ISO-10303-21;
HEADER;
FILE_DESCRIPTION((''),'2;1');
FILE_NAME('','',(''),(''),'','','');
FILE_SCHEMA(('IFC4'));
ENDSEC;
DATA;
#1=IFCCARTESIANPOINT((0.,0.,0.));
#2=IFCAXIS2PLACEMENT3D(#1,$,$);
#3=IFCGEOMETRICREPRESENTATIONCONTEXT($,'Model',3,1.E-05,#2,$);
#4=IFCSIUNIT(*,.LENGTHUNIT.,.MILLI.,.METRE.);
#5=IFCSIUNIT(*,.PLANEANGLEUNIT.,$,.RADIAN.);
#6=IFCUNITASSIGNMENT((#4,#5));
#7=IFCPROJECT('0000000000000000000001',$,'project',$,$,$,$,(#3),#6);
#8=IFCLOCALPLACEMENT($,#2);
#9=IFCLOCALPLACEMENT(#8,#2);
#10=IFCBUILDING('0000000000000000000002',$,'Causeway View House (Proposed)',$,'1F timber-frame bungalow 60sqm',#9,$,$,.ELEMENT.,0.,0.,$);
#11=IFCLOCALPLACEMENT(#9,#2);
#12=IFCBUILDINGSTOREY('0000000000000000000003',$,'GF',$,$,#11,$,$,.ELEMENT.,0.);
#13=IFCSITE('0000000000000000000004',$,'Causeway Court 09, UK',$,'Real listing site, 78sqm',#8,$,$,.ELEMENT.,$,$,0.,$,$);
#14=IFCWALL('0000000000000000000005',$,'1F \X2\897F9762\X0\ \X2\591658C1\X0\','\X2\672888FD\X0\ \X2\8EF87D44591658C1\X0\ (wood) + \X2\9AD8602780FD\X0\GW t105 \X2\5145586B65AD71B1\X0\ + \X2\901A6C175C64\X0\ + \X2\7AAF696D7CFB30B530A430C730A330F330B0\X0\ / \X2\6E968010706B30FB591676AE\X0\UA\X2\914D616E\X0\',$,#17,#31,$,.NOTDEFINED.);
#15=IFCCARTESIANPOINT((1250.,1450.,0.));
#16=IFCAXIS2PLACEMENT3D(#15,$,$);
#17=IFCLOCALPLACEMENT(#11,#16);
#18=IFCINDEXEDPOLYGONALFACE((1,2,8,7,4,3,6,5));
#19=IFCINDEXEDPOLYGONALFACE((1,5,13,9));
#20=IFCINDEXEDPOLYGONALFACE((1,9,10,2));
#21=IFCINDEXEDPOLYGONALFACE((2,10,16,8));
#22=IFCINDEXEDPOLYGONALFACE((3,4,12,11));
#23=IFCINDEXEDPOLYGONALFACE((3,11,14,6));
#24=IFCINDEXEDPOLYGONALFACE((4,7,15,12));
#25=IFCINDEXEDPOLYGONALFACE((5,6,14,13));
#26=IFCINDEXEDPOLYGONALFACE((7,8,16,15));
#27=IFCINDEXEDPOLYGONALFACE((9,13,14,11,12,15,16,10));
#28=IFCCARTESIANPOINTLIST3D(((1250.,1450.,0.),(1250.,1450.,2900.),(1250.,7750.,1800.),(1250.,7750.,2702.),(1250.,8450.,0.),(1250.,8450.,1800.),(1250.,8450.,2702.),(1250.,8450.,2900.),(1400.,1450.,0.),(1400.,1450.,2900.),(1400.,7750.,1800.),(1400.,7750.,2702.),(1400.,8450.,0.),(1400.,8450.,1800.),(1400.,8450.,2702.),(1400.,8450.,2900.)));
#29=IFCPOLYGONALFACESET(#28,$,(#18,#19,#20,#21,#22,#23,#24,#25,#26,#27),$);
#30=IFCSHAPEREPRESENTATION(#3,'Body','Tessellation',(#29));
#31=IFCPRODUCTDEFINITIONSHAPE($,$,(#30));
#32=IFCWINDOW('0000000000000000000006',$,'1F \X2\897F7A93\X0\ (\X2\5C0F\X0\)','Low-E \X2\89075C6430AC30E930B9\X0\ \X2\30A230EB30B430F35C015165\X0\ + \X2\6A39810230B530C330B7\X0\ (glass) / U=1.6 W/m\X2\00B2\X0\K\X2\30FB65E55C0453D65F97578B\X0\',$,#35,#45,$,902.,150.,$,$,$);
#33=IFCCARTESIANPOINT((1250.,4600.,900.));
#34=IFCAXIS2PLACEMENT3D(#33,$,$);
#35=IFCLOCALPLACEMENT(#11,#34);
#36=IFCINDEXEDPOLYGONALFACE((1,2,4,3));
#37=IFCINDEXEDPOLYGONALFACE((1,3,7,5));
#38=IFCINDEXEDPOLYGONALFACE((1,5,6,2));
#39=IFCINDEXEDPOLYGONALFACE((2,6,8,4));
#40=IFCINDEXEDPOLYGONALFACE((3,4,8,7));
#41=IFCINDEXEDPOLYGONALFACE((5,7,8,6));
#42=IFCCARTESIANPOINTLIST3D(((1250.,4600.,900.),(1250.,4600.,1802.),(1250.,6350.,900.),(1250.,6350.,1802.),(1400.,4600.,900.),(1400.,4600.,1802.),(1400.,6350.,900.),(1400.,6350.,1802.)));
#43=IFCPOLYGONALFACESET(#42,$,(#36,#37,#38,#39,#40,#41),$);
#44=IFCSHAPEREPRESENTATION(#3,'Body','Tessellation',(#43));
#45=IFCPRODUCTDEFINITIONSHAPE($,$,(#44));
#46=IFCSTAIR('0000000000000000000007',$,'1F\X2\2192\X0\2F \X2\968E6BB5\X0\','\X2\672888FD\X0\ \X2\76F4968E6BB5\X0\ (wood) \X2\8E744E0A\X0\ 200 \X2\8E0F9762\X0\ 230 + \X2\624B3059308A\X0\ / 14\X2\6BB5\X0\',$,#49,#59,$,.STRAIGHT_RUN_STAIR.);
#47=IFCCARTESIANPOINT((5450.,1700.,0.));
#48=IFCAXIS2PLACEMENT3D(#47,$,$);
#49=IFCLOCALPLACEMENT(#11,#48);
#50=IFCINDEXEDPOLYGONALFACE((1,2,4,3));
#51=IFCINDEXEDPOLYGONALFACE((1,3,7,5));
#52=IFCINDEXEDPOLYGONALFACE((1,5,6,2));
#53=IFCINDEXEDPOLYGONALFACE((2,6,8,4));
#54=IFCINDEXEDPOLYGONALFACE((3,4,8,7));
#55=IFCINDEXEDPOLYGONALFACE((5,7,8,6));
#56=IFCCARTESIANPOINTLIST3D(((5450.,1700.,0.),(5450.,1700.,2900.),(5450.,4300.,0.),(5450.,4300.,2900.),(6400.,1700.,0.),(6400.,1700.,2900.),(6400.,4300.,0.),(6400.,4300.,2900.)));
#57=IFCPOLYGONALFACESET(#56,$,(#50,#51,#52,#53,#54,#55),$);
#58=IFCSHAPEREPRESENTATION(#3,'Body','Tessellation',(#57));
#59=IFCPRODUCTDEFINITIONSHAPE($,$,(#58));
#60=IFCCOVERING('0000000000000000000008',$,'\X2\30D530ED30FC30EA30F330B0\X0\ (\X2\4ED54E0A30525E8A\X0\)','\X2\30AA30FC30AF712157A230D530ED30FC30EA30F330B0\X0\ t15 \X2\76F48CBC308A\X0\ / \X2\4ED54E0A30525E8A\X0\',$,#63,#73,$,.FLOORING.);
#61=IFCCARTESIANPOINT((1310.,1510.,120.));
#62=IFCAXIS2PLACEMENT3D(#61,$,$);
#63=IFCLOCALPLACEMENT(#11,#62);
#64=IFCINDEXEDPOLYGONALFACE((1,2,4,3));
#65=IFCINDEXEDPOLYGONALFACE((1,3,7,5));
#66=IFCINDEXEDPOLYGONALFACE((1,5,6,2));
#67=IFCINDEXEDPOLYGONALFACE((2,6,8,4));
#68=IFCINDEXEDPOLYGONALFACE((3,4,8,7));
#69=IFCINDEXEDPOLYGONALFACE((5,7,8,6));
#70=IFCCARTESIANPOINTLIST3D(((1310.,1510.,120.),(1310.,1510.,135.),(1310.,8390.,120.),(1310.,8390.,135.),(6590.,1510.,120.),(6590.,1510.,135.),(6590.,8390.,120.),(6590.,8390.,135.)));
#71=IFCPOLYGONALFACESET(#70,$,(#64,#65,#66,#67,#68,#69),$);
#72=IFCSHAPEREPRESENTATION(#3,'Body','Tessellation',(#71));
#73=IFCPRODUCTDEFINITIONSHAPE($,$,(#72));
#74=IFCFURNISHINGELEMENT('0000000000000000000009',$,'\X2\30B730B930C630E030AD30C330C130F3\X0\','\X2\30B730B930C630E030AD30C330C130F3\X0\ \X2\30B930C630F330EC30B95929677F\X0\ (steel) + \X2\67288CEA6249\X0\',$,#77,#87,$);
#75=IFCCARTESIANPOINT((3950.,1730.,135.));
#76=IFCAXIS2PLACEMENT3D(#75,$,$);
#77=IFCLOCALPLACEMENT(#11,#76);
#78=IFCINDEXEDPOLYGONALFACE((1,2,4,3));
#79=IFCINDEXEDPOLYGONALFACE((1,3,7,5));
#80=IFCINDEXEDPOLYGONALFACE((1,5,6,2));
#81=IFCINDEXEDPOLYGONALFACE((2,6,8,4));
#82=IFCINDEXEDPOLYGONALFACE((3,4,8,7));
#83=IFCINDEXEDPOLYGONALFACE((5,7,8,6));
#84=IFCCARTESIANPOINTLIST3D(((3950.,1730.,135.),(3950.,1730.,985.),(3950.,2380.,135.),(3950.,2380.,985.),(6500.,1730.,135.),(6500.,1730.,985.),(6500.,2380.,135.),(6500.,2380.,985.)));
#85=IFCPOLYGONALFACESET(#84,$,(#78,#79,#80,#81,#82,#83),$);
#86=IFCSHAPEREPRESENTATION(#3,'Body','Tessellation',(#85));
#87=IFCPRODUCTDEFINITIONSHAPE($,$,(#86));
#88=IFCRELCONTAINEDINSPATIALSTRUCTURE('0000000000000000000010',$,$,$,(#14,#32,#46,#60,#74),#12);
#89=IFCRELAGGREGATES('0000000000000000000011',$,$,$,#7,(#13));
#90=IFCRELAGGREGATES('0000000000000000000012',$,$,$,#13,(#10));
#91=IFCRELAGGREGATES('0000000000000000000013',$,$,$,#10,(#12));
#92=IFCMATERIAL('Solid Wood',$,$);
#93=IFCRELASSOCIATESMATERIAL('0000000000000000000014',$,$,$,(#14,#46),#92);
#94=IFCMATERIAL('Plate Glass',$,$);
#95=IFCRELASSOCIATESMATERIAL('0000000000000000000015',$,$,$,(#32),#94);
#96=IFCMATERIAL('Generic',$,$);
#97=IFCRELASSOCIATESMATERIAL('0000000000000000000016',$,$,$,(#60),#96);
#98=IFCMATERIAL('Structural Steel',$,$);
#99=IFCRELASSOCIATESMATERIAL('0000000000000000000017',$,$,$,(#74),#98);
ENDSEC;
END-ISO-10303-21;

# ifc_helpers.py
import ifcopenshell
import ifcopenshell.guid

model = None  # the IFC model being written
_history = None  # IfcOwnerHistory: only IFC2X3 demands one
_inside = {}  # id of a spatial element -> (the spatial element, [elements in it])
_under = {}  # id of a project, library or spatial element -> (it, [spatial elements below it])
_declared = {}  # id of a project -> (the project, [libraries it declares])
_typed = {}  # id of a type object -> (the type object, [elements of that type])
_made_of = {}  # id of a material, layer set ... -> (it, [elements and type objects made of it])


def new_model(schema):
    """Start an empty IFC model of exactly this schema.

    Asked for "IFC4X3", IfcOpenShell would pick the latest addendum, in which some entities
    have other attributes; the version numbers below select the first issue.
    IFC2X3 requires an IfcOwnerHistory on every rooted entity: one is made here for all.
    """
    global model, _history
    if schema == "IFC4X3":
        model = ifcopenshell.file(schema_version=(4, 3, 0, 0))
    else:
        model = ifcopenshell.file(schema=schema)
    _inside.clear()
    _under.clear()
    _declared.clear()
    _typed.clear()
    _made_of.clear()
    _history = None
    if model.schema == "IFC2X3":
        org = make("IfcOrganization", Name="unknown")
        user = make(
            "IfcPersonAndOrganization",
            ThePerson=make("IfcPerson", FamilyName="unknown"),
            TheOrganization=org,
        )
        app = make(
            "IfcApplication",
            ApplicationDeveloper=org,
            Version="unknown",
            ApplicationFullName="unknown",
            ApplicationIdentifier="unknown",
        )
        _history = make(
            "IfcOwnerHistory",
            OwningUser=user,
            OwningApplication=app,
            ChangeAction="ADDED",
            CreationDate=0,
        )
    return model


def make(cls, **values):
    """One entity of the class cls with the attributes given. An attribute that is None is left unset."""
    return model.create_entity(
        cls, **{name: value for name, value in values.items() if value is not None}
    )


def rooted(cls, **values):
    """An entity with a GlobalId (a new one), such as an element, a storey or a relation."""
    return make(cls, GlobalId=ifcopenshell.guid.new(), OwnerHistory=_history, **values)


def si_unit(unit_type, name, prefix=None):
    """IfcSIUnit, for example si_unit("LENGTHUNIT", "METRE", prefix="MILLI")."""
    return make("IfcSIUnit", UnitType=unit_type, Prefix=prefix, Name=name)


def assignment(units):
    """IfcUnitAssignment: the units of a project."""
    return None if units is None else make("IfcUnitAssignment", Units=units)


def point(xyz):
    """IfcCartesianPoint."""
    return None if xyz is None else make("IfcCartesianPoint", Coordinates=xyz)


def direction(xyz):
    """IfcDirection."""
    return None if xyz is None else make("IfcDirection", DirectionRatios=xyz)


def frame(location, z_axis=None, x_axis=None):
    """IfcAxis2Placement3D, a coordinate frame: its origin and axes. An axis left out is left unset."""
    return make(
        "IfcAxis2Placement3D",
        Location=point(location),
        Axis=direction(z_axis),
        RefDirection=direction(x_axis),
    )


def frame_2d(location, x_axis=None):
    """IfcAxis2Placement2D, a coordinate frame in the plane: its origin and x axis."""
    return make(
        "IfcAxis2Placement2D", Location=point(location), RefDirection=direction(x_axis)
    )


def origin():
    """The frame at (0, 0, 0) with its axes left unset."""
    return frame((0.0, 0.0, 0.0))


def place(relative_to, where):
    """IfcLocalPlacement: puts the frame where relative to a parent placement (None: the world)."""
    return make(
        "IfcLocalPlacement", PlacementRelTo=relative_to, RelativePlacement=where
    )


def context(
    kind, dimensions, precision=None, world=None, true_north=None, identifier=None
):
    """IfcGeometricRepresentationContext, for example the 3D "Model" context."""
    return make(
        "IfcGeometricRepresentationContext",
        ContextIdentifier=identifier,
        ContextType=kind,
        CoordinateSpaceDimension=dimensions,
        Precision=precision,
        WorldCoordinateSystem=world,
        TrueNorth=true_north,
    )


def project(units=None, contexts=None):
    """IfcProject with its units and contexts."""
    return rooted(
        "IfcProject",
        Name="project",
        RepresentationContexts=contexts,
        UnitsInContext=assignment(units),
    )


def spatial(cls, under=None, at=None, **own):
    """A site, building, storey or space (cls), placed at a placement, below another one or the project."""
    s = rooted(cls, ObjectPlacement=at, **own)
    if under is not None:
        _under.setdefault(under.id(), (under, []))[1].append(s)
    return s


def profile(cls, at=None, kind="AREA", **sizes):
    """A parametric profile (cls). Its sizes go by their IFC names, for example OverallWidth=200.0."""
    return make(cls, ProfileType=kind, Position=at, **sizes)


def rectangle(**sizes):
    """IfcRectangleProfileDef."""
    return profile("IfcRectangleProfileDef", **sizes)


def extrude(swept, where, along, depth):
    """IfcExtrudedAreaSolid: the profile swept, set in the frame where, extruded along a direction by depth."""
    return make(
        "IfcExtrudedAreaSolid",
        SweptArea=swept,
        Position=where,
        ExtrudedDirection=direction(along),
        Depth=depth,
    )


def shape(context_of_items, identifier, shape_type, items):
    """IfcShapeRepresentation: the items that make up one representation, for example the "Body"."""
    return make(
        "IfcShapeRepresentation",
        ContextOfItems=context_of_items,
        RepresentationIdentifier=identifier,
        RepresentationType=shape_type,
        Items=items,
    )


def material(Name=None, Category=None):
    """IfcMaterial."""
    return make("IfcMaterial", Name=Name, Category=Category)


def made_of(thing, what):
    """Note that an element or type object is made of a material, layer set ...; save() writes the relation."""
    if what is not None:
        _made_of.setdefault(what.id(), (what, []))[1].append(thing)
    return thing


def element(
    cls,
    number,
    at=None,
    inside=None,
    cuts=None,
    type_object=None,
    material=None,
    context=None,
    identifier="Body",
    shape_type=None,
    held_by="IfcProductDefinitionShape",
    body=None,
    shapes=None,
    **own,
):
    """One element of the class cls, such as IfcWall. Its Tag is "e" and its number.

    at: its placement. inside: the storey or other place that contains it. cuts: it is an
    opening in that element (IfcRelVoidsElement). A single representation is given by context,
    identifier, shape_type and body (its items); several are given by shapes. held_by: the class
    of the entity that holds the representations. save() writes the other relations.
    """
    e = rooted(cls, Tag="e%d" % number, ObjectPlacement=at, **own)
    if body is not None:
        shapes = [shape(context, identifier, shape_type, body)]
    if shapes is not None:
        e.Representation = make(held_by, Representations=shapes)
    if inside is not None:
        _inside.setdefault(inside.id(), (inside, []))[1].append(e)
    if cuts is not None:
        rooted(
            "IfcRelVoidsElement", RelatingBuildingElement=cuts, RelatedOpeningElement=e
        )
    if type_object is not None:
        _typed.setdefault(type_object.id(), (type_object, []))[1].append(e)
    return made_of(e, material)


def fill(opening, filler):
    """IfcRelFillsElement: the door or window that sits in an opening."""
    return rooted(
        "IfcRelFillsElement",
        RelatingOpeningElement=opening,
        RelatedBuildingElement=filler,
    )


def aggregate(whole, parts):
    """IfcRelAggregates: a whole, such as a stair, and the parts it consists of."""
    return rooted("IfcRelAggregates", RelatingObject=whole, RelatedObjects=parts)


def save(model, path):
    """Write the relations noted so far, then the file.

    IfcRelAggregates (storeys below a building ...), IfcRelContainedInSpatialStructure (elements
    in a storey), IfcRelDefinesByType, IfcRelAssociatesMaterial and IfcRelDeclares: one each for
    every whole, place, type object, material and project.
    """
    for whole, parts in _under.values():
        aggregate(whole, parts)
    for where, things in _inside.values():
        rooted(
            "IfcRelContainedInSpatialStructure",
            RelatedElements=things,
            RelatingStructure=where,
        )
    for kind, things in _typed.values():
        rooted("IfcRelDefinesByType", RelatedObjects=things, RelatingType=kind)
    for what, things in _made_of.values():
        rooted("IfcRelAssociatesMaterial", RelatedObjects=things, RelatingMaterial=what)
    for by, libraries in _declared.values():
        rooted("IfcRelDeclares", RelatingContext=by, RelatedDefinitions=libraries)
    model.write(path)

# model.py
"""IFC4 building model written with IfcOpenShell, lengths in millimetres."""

from ifc_helpers import new_model, si_unit, frame, frame_2d, origin, place, context, project, spatial, rectangle, extrude, material, element, fill, save


model = new_model("IFC4")

# Units and contexts
model_context = context("Model", 3, precision=1e-05, world=origin())
ifc_project = project(units=[si_unit("LENGTHUNIT", "METRE", prefix="MILLI"), si_unit("PLANEANGLEUNIT", "RADIAN")], contexts=[model_context])

# Site, building, storey
site_placement = place(None, origin())
site = spatial("IfcSite", under=ifc_project, at=site_placement, Name="Causeway Court 09, UK", ObjectType="Real listing site, 78sqm", CompositionType="ELEMENT", RefElevation=0.0)
building_placement = place(site_placement, origin())
building = spatial("IfcBuilding", under=site, at=building_placement, Name="Causeway View House (Proposed)", ObjectType="1F timber-frame bungalow 60sqm", CompositionType="ELEMENT", ElevationOfRefHeight=0.0, ElevationOfTerrain=0.0)
storey_placement = place(building_placement, origin())
storey = spatial("IfcBuildingStorey", under=building, at=storey_placement, Name="GF", CompositionType="ELEMENT", Elevation=0.0)

# Shared definitions
ifc_material_1 = material(Name="Solid Wood")
ifc_material_2 = material(Name="Generic")

# Shared definitions
ifc_material_3 = material(Name="Plate Glass")

# Wall, opening, window
wall_1_placement = place(storey_placement, frame((1250.0, 1450.0, 0.0)))
wall_1 = element("IfcWall", 1, at=wall_1_placement, inside=storey, material=ifc_material_1, Name="1F 西面 外壁", Description="木製 軸組外壁 (wood) + 高性能GW t105 充填断熱 + 通気層 + 窯業系サイディング / 準耐火・外皮UA配慮", PredefinedType="NOTDEFINED", context=model_context, shape_type="SweptSolid", body=[
    extrude(rectangle(XDim=150.0, YDim=7000.0, at=frame_2d((75.0, 3500.0))), frame((1250.0, 1450.0, 0.0)), (0.0, 0.0, 1.0), 2900.0),
])
opening_1_placement = place(storey_placement, frame((1250.0, 4600.0, 900.0)))
opening_1 = element("IfcOpeningElement", 2, at=opening_1_placement, cuts=wall_1, PredefinedType="NOTDEFINED", context=model_context, shape_type="SweptSolid", body=[
    extrude(rectangle(XDim=150.0, YDim=1750.0, at=frame_2d((75.0, 875.0))), frame((1250.0, 4600.0, 900.0)), (0.0, 0.0, 1.0), 902.0),
])
window_1_placement = place(storey_placement, frame((1250.0, 4600.0, 900.0)))
window_1 = element("IfcWindow", 3, at=window_1_placement, inside=storey, material=ifc_material_3, Name="1F 西窓 (小)", Description="Low-E 複層ガラス アルゴン封入 + 樹脂サッシ (glass) / U=1.6 W/m²K・日射取得型", OverallHeight=902.0, OverallWidth=150.0, context=model_context, shape_type="SweptSolid", body=[
    extrude(rectangle(XDim=150.0, YDim=1750.0, at=frame_2d((75.0, 875.0))), frame((1250.0, 4600.0, 900.0)), (0.0, 0.0, 1.0), 902.0),
])
fill(opening_1, window_1)

# Stair
stair_placement = place(storey_placement, frame((5450.0, 1700.0, 0.0)))
element("IfcStair", 4, at=stair_placement, inside=storey, material=ifc_material_1, Name="1F→2F 階段", Description="木製 直階段 (wood) 蹴上 200 踏面 230 + 手すり / 14段", PredefinedType="STRAIGHT_RUN_STAIR", context=model_context, shape_type="SweptSolid", body=[
    extrude(rectangle(XDim=950.0, YDim=2600.0, at=frame_2d((475.0, 1300.0))), frame((5450.0, 1700.0, 0.0)), (0.0, 0.0, 1.0), 2900.0),
])

# Covering
covering_placement = place(storey_placement, frame((1310.0, 1510.0, 120.0)))
element("IfcCovering", 5, at=covering_placement, inside=storey, material=ifc_material_2, Name="フローリング (仕上げ床)", Description="オーク無垢フローリング t15 直貼り / 仕上げ床", PredefinedType="FLOORING", context=model_context, shape_type="SweptSolid", body=[
    extrude(rectangle(XDim=5280.0, YDim=6880.0, at=frame_2d((2640.0, 3440.0))), frame((1310.0, 1510.0, 120.0)), (0.0, 0.0, 1.0), 15.0),
])

# Furnishing element
ifc_material_4 = material(Name="Structural Steel")
furnishing_placement = place(storey_placement, frame((3950.0, 1730.0, 135.0)))
element("IfcFurnishingElement", 6, at=furnishing_placement, inside=storey, material=ifc_material_4, Name="システムキッチン", Description="システムキッチン ステンレス天板 (steel) + 木質扉", context=model_context, shape_type="SweptSolid", body=[
    extrude(rectangle(XDim=2550.0, YDim=650.0, at=frame_2d((1275.0, 325.0))), frame((3950.0, 1730.0, 135.0)), (0.0, 0.0, 1.0), 850.0),
])

save(model, "model.ifc")
